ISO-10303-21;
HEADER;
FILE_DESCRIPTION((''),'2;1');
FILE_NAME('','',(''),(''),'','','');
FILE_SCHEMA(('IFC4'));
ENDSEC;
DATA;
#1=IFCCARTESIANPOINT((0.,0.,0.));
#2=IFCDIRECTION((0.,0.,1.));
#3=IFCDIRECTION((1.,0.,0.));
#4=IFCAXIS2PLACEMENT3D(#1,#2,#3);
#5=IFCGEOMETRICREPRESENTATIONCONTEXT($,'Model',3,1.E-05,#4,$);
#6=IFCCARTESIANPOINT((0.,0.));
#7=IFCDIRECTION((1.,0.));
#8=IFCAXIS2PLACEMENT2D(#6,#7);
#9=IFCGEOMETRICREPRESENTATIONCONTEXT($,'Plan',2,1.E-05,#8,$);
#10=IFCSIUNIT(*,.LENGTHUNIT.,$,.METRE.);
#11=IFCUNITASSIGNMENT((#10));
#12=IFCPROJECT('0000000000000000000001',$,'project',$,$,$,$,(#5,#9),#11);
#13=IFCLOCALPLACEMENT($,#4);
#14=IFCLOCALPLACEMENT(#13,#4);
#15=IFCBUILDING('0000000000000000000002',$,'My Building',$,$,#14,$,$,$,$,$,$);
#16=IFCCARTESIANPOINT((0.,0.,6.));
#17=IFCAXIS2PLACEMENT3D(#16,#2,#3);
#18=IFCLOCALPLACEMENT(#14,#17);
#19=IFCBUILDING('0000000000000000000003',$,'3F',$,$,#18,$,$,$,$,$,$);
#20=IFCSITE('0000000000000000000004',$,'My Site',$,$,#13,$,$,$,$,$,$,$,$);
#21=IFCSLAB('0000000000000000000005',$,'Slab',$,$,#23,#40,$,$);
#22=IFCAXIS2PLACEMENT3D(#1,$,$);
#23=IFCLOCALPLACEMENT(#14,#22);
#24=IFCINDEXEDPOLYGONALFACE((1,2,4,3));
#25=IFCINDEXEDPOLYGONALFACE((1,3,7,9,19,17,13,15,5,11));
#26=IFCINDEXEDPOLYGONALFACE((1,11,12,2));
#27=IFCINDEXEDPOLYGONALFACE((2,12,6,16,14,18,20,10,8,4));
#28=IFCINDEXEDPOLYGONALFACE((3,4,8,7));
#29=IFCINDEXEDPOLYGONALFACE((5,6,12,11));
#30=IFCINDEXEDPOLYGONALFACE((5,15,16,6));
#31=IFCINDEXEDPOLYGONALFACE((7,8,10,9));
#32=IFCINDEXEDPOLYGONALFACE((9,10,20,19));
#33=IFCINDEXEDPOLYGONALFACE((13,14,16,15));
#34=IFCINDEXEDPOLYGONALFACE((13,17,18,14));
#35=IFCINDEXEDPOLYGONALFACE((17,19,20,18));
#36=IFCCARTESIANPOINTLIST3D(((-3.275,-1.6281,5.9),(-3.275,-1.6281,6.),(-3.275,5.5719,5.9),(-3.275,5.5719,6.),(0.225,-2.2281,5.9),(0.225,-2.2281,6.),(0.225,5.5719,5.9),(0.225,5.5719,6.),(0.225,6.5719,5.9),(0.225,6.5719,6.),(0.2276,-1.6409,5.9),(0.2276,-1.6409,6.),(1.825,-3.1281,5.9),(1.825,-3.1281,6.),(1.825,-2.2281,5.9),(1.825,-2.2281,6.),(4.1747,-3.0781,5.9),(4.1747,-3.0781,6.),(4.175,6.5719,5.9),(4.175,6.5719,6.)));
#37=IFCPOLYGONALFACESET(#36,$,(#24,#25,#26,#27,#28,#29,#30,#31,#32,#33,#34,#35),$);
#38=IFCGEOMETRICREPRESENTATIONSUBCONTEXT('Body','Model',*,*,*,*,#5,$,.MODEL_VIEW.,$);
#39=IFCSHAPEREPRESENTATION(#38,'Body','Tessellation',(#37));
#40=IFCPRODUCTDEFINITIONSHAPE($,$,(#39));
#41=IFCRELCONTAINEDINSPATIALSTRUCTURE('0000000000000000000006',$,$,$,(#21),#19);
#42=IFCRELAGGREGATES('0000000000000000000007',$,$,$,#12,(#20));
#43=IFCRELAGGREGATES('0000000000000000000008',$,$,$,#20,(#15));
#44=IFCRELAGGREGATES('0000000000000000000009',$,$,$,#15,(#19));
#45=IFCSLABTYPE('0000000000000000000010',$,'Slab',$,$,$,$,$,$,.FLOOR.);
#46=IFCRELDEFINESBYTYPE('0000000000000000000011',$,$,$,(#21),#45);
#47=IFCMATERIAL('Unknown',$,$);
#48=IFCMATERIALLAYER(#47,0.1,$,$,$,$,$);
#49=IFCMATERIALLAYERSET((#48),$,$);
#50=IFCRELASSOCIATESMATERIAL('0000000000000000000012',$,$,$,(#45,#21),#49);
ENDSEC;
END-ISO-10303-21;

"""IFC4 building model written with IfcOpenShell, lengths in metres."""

from ifc_helpers import new_model, si_unit, frame, origin_with_axes, origin_2d_with_axis, place, context, subcontext, project, spatial, indexed_curve, outline, extrude, material, layer, layer_set, layer_usage, type_object, element, save


model = new_model("IFC4")

# Units and contexts
model_context = context("Model", 3, precision=1e-05, world=origin_with_axes())
plan_context = context("Plan", 2, precision=1e-05, world=origin_2d_with_axis())
body_context = subcontext(model_context, "Body", "Model", "MODEL_VIEW")
ifc_project = project(units=[si_unit("LENGTHUNIT", "METRE")], contexts=[model_context, plan_context])

# Site, buildings
site_placement = place(None, origin_with_axes())
site = spatial("IfcSite", under=ifc_project, at=site_placement, Name="My Site")
building_1_placement = place(site_placement, origin_with_axes())
building_1 = spatial("IfcBuilding", under=site, at=building_1_placement, Name="My Building")
building_2_placement = place(building_1_placement, frame((0.0, 0.0, 6.0), z_axis=(0.0, 0.0, 1.0), x_axis=(1.0, 0.0, 0.0)))
building_2 = spatial("IfcBuilding", under=building_1, at=building_2_placement, Name="3F")

# Slab
ifc_material = material(Name="Unknown")
ifc_layer = layer(ifc_material, 0.1)
ifc_layer_set = layer_set([ifc_layer])
ifc_layer_usage = layer_usage(ifc_layer_set, "AXIS3", "POSITIVE", -0.1)
slab_type = type_object("IfcSlabType", Name="Slab", PredefinedType="FLOOR", material=ifc_layer_set)
slab_placement = place(building_2_placement, frame((4.175, 6.5719, 0.0), z_axis=(0.0, 0.0, 1.0), x_axis=(1.0, 0.0, 0.0)))
element("IfcSlab", 1, at=slab_placement, inside=building_2, type_object=slab_type, material=ifc_layer_usage, Name="Slab", context=body_context, shape_type="SweptSolid", body=[
    extrude(outline(indexed_curve([(0.0, 0.0), (-3.95, 0.0), (-3.95, -1.0), (-7.45, -1.0), (-7.45, -8.2), (-3.9474, -8.2128), (-3.95, -8.8), (-2.35, -8.8), (-2.35, -9.7), (-0.0003, -9.65), (0.0, 0.0)])), frame((0.0, 0.0, -0.1), z_axis=(0.0, 0.0, 1.0), x_axis=(1.0, 0.0, 0.0)), (0.0, 0.0, 1.0), 0.1),
])

save(model, "model.ifc")
